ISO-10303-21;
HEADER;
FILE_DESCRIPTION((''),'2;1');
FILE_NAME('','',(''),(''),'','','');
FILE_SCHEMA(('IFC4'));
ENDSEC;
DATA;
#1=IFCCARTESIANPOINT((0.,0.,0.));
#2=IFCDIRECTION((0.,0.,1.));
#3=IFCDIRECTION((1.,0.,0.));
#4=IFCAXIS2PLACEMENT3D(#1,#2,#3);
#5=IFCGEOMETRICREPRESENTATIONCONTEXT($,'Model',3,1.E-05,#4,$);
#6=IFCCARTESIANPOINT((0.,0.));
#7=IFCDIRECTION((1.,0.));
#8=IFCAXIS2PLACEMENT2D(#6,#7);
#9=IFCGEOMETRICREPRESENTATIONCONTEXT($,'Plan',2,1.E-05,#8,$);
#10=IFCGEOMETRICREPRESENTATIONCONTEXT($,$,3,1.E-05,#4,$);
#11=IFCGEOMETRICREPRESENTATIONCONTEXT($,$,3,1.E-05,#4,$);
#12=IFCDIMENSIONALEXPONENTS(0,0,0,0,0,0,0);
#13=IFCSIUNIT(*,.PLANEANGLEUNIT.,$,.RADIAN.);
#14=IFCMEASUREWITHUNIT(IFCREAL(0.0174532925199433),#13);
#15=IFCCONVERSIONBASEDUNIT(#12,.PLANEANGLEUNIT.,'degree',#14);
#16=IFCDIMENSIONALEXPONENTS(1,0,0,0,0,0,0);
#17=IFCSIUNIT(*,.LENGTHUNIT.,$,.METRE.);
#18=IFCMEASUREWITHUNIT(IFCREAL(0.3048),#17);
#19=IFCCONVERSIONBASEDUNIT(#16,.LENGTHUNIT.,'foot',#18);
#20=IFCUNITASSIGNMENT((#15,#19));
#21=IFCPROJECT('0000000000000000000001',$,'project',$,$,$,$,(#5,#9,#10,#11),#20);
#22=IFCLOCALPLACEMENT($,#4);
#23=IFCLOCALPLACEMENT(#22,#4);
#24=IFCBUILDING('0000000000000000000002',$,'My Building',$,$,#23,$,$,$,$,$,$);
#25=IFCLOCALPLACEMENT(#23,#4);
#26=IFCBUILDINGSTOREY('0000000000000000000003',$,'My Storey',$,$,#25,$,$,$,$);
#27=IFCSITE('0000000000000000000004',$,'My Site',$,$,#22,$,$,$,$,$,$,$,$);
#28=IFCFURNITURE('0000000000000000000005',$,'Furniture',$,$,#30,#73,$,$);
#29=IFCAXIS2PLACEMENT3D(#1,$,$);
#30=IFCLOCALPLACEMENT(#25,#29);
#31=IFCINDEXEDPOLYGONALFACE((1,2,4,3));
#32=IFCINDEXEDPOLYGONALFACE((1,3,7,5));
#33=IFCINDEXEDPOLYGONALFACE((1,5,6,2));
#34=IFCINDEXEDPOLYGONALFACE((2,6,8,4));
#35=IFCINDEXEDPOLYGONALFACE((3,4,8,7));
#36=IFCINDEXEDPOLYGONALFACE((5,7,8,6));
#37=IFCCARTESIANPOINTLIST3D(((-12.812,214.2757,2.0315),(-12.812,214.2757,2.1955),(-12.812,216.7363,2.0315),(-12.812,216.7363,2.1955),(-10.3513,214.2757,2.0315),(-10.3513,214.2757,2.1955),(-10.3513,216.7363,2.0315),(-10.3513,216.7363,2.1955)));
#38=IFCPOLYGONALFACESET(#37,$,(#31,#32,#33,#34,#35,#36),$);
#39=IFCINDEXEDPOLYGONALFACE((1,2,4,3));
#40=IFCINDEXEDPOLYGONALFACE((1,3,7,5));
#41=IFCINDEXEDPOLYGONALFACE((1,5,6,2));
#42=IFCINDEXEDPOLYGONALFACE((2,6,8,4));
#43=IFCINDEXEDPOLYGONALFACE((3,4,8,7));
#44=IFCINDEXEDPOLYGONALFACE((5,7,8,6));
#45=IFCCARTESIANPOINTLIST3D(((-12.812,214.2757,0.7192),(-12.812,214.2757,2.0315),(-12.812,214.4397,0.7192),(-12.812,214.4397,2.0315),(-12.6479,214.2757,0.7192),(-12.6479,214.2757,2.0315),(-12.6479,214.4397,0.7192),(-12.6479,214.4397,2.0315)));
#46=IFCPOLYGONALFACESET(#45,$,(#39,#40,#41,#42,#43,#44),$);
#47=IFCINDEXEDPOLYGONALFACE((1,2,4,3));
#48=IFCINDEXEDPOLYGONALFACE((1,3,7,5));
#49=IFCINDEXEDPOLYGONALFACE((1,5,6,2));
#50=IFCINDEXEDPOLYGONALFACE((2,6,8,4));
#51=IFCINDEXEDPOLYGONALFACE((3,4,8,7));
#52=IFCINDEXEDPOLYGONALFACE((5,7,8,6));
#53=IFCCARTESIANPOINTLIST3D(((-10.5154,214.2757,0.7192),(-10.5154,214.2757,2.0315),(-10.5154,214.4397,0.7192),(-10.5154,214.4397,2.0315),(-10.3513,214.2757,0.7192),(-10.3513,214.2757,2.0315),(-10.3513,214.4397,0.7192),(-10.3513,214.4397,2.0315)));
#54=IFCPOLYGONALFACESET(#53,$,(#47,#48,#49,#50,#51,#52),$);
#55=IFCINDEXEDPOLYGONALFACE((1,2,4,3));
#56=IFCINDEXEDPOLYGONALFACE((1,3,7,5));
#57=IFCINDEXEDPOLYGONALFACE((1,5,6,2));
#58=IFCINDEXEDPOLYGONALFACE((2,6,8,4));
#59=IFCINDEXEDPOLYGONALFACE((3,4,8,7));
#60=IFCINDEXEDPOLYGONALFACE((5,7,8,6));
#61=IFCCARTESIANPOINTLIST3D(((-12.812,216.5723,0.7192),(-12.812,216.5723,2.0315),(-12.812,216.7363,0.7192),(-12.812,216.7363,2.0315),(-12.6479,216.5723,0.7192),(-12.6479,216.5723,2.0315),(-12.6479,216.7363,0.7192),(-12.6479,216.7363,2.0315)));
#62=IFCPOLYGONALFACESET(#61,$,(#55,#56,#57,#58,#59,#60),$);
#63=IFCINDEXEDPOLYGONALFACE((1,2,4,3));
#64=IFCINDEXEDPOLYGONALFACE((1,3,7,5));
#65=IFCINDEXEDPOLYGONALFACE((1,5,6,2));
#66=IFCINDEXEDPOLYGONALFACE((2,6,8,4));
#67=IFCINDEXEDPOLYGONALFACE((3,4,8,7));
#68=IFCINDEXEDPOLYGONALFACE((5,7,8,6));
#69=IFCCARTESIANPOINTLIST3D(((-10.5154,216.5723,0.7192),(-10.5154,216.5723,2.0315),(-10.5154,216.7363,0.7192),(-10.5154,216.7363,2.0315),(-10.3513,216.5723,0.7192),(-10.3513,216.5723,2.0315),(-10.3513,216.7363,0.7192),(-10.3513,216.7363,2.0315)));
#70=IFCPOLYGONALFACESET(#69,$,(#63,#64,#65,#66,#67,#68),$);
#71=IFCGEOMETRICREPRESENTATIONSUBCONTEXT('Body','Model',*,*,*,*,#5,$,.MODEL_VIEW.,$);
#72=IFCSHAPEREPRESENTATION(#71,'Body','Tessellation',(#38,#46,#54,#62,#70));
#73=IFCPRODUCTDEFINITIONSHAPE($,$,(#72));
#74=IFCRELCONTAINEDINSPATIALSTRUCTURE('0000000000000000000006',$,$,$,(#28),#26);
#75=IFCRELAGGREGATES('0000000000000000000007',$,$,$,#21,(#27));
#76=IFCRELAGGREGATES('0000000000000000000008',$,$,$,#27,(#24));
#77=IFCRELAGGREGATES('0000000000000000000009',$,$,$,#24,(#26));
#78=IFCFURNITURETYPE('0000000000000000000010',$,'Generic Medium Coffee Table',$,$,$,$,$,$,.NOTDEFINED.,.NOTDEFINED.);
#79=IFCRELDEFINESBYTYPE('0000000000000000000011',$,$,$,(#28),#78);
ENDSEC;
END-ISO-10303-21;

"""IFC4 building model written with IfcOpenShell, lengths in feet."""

from ifc_helpers import new_model, entity, si_unit, converted_unit, frame, origin_with_axes, origin_2d_with_axis, place, context, subcontext, project, spatial, line, indexed_curve, outline, extrude, shape, source, transform, mapped, type_object, type_shapes, element, save


model = new_model("IFC4")

# Units and contexts
model_context = context("Model", 3, precision=1e-05, world=origin_with_axes())
plan_context = context("Plan", 2, precision=1e-05, world=origin_2d_with_axis())
context_of_model_1 = context(None, 3, precision=1e-05, world=origin_with_axes())
context_of_model_2 = context(None, 3, precision=1e-05, world=origin_with_axes())
body_context_1 = subcontext(model_context, "Body", "Model", "MODEL_VIEW")
body_context_2 = subcontext(plan_context, "Body", "Plan", "PLAN_VIEW")
ifc_project = project(units=[converted_unit("PLANEANGLEUNIT", "degree", entity("IfcReal", 0.0174532925199433), si_unit("PLANEANGLEUNIT", "RADIAN"), dimensions=[0, 0, 0, 0, 0, 0, 0]), converted_unit("LENGTHUNIT", "foot", entity("IfcReal", 0.3048), si_unit("LENGTHUNIT", "METRE"), dimensions=[1, 0, 0, 0, 0, 0, 0])], contexts=[model_context, plan_context, context_of_model_1, context_of_model_2])

# Site, building, storey
site_placement = place(None, origin_with_axes())
site = spatial("IfcSite", under=ifc_project, at=site_placement, Name="My Site")
building_placement = place(site_placement, origin_with_axes())
building = spatial("IfcBuilding", under=site, at=building_placement, Name="My Building")
storey_placement = place(building_placement, origin_with_axes())
storey = spatial("IfcBuildingStorey", under=building, at=storey_placement, Name="My Storey")

# Furniture
furniture_type_1 = type_object("IfcFurnitureType", Name="Generic Medium Coffee Table", AssemblyPlace="NOTDEFINED", PredefinedType="NOTDEFINED")
shared_shape_1 = source(origin_with_axes(), body_context_1, "Body", "SweptSolid", [
    extrude(outline(indexed_curve([(0.0, 0.0), (2.4606, 0.0), (2.4606, 2.4606), (0.0, 2.4606)], segments=[line(1, 2), line(2, 3), line(3, 4), line(4, 1)])), frame((-1.2303, -1.2303, 1.3123), z_axis=(0.0, 0.0, 1.0), x_axis=(1.0, 0.0, 0.0)), (0.0, 0.0, 1.0), 0.164),
    extrude(outline(indexed_curve([(0.0, 0.0), (0.164, 0.0), (0.164, 0.164), (0.0, 0.164)], segments=[line(1, 2), line(2, 3), line(3, 4), line(4, 1)])), frame((-1.2303, -1.2303, 0.0), z_axis=(0.0, 0.0, 1.0), x_axis=(1.0, 0.0, 0.0)), (0.0, 0.0, 1.0), 1.3123),
    extrude(outline(indexed_curve([(2.4606, 0.0), (2.2966, 0.0), (2.2966, 0.164), (2.4606, 0.164)], segments=[line(1, 2), line(2, 3), line(3, 4), line(4, 1)])), frame((-1.2303, -1.2303, 0.0), z_axis=(0.0, 0.0, 1.0), x_axis=(1.0, 0.0, 0.0)), (0.0, 0.0, 1.0), 1.3123),
    extrude(outline(indexed_curve([(0.0, 2.4606), (0.164, 2.4606), (0.164, 2.2966), (0.0, 2.2966)], segments=[line(1, 2), line(2, 3), line(3, 4), line(4, 1)])), frame((-1.2303, -1.2303, 0.0), z_axis=(0.0, 0.0, 1.0), x_axis=(1.0, 0.0, 0.0)), (0.0, 0.0, 1.0), 1.3123),
    extrude(outline(indexed_curve([(2.4606, 2.4606), (2.2966, 2.4606), (2.2966, 2.2966), (2.4606, 2.2966)], segments=[line(1, 2), line(2, 3), line(3, 4), line(4, 1)])), frame((-1.2303, -1.2303, 0.0), z_axis=(0.0, 0.0, 1.0), x_axis=(1.0, 0.0, 0.0)), (0.0, 0.0, 1.0), 1.3123),
])
shared_shape_2 = source(origin_with_axes(), body_context_2, "Body", "Annotation2D", [
    entity("IfcAnnotationFillArea", entity("IfcIndexedPolyCurve", entity("IfcCartesianPointList2D", [[-1.2303, -1.2303], [1.2303, -1.2303], [1.2303, 1.2303], [-1.2303, 1.2303]]), [entity("IfcLineIndex", [1, 4]), entity("IfcLineIndex", [4, 3]), entity("IfcLineIndex", [3, 2]), entity("IfcLineIndex", [2, 1])])),
])
type_shapes(furniture_type_1, [shared_shape_1, shared_shape_2])
for number, where, z_axis, x_axis, name in (
    (1, (-11.5817, 215.506, 0.7192), (0.0, 0.0, 1.0), (1.0, 0.0, 0.0), "Furniture"),
):
    element("IfcFurniture", number, at=place(storey_placement, frame(where, z_axis=z_axis, x_axis=x_axis)), inside=storey, type_object=furniture_type_1, Name=name, shapes=[
        shape(body_context_1, "Body", "MappedRepresentation", [mapped(shared_shape_1, transform((0.0, 0.0, 0.0), x_axis=(1.0, 0.0, 0.0), y_axis=(0.0, 1.0, 0.0), z_axis=(0.0, 0.0, 1.0), scale=1.0))]),
        shape(body_context_2, "Body", "MappedRepresentation", [mapped(shared_shape_2, transform((0.0, 0.0, 0.0), x_axis=(1.0, 0.0, 0.0), y_axis=(0.0, 1.0, 0.0), z_axis=(0.0, 0.0, 1.0), scale=1.0))]),
    ])

save(model, "model.ifc")
